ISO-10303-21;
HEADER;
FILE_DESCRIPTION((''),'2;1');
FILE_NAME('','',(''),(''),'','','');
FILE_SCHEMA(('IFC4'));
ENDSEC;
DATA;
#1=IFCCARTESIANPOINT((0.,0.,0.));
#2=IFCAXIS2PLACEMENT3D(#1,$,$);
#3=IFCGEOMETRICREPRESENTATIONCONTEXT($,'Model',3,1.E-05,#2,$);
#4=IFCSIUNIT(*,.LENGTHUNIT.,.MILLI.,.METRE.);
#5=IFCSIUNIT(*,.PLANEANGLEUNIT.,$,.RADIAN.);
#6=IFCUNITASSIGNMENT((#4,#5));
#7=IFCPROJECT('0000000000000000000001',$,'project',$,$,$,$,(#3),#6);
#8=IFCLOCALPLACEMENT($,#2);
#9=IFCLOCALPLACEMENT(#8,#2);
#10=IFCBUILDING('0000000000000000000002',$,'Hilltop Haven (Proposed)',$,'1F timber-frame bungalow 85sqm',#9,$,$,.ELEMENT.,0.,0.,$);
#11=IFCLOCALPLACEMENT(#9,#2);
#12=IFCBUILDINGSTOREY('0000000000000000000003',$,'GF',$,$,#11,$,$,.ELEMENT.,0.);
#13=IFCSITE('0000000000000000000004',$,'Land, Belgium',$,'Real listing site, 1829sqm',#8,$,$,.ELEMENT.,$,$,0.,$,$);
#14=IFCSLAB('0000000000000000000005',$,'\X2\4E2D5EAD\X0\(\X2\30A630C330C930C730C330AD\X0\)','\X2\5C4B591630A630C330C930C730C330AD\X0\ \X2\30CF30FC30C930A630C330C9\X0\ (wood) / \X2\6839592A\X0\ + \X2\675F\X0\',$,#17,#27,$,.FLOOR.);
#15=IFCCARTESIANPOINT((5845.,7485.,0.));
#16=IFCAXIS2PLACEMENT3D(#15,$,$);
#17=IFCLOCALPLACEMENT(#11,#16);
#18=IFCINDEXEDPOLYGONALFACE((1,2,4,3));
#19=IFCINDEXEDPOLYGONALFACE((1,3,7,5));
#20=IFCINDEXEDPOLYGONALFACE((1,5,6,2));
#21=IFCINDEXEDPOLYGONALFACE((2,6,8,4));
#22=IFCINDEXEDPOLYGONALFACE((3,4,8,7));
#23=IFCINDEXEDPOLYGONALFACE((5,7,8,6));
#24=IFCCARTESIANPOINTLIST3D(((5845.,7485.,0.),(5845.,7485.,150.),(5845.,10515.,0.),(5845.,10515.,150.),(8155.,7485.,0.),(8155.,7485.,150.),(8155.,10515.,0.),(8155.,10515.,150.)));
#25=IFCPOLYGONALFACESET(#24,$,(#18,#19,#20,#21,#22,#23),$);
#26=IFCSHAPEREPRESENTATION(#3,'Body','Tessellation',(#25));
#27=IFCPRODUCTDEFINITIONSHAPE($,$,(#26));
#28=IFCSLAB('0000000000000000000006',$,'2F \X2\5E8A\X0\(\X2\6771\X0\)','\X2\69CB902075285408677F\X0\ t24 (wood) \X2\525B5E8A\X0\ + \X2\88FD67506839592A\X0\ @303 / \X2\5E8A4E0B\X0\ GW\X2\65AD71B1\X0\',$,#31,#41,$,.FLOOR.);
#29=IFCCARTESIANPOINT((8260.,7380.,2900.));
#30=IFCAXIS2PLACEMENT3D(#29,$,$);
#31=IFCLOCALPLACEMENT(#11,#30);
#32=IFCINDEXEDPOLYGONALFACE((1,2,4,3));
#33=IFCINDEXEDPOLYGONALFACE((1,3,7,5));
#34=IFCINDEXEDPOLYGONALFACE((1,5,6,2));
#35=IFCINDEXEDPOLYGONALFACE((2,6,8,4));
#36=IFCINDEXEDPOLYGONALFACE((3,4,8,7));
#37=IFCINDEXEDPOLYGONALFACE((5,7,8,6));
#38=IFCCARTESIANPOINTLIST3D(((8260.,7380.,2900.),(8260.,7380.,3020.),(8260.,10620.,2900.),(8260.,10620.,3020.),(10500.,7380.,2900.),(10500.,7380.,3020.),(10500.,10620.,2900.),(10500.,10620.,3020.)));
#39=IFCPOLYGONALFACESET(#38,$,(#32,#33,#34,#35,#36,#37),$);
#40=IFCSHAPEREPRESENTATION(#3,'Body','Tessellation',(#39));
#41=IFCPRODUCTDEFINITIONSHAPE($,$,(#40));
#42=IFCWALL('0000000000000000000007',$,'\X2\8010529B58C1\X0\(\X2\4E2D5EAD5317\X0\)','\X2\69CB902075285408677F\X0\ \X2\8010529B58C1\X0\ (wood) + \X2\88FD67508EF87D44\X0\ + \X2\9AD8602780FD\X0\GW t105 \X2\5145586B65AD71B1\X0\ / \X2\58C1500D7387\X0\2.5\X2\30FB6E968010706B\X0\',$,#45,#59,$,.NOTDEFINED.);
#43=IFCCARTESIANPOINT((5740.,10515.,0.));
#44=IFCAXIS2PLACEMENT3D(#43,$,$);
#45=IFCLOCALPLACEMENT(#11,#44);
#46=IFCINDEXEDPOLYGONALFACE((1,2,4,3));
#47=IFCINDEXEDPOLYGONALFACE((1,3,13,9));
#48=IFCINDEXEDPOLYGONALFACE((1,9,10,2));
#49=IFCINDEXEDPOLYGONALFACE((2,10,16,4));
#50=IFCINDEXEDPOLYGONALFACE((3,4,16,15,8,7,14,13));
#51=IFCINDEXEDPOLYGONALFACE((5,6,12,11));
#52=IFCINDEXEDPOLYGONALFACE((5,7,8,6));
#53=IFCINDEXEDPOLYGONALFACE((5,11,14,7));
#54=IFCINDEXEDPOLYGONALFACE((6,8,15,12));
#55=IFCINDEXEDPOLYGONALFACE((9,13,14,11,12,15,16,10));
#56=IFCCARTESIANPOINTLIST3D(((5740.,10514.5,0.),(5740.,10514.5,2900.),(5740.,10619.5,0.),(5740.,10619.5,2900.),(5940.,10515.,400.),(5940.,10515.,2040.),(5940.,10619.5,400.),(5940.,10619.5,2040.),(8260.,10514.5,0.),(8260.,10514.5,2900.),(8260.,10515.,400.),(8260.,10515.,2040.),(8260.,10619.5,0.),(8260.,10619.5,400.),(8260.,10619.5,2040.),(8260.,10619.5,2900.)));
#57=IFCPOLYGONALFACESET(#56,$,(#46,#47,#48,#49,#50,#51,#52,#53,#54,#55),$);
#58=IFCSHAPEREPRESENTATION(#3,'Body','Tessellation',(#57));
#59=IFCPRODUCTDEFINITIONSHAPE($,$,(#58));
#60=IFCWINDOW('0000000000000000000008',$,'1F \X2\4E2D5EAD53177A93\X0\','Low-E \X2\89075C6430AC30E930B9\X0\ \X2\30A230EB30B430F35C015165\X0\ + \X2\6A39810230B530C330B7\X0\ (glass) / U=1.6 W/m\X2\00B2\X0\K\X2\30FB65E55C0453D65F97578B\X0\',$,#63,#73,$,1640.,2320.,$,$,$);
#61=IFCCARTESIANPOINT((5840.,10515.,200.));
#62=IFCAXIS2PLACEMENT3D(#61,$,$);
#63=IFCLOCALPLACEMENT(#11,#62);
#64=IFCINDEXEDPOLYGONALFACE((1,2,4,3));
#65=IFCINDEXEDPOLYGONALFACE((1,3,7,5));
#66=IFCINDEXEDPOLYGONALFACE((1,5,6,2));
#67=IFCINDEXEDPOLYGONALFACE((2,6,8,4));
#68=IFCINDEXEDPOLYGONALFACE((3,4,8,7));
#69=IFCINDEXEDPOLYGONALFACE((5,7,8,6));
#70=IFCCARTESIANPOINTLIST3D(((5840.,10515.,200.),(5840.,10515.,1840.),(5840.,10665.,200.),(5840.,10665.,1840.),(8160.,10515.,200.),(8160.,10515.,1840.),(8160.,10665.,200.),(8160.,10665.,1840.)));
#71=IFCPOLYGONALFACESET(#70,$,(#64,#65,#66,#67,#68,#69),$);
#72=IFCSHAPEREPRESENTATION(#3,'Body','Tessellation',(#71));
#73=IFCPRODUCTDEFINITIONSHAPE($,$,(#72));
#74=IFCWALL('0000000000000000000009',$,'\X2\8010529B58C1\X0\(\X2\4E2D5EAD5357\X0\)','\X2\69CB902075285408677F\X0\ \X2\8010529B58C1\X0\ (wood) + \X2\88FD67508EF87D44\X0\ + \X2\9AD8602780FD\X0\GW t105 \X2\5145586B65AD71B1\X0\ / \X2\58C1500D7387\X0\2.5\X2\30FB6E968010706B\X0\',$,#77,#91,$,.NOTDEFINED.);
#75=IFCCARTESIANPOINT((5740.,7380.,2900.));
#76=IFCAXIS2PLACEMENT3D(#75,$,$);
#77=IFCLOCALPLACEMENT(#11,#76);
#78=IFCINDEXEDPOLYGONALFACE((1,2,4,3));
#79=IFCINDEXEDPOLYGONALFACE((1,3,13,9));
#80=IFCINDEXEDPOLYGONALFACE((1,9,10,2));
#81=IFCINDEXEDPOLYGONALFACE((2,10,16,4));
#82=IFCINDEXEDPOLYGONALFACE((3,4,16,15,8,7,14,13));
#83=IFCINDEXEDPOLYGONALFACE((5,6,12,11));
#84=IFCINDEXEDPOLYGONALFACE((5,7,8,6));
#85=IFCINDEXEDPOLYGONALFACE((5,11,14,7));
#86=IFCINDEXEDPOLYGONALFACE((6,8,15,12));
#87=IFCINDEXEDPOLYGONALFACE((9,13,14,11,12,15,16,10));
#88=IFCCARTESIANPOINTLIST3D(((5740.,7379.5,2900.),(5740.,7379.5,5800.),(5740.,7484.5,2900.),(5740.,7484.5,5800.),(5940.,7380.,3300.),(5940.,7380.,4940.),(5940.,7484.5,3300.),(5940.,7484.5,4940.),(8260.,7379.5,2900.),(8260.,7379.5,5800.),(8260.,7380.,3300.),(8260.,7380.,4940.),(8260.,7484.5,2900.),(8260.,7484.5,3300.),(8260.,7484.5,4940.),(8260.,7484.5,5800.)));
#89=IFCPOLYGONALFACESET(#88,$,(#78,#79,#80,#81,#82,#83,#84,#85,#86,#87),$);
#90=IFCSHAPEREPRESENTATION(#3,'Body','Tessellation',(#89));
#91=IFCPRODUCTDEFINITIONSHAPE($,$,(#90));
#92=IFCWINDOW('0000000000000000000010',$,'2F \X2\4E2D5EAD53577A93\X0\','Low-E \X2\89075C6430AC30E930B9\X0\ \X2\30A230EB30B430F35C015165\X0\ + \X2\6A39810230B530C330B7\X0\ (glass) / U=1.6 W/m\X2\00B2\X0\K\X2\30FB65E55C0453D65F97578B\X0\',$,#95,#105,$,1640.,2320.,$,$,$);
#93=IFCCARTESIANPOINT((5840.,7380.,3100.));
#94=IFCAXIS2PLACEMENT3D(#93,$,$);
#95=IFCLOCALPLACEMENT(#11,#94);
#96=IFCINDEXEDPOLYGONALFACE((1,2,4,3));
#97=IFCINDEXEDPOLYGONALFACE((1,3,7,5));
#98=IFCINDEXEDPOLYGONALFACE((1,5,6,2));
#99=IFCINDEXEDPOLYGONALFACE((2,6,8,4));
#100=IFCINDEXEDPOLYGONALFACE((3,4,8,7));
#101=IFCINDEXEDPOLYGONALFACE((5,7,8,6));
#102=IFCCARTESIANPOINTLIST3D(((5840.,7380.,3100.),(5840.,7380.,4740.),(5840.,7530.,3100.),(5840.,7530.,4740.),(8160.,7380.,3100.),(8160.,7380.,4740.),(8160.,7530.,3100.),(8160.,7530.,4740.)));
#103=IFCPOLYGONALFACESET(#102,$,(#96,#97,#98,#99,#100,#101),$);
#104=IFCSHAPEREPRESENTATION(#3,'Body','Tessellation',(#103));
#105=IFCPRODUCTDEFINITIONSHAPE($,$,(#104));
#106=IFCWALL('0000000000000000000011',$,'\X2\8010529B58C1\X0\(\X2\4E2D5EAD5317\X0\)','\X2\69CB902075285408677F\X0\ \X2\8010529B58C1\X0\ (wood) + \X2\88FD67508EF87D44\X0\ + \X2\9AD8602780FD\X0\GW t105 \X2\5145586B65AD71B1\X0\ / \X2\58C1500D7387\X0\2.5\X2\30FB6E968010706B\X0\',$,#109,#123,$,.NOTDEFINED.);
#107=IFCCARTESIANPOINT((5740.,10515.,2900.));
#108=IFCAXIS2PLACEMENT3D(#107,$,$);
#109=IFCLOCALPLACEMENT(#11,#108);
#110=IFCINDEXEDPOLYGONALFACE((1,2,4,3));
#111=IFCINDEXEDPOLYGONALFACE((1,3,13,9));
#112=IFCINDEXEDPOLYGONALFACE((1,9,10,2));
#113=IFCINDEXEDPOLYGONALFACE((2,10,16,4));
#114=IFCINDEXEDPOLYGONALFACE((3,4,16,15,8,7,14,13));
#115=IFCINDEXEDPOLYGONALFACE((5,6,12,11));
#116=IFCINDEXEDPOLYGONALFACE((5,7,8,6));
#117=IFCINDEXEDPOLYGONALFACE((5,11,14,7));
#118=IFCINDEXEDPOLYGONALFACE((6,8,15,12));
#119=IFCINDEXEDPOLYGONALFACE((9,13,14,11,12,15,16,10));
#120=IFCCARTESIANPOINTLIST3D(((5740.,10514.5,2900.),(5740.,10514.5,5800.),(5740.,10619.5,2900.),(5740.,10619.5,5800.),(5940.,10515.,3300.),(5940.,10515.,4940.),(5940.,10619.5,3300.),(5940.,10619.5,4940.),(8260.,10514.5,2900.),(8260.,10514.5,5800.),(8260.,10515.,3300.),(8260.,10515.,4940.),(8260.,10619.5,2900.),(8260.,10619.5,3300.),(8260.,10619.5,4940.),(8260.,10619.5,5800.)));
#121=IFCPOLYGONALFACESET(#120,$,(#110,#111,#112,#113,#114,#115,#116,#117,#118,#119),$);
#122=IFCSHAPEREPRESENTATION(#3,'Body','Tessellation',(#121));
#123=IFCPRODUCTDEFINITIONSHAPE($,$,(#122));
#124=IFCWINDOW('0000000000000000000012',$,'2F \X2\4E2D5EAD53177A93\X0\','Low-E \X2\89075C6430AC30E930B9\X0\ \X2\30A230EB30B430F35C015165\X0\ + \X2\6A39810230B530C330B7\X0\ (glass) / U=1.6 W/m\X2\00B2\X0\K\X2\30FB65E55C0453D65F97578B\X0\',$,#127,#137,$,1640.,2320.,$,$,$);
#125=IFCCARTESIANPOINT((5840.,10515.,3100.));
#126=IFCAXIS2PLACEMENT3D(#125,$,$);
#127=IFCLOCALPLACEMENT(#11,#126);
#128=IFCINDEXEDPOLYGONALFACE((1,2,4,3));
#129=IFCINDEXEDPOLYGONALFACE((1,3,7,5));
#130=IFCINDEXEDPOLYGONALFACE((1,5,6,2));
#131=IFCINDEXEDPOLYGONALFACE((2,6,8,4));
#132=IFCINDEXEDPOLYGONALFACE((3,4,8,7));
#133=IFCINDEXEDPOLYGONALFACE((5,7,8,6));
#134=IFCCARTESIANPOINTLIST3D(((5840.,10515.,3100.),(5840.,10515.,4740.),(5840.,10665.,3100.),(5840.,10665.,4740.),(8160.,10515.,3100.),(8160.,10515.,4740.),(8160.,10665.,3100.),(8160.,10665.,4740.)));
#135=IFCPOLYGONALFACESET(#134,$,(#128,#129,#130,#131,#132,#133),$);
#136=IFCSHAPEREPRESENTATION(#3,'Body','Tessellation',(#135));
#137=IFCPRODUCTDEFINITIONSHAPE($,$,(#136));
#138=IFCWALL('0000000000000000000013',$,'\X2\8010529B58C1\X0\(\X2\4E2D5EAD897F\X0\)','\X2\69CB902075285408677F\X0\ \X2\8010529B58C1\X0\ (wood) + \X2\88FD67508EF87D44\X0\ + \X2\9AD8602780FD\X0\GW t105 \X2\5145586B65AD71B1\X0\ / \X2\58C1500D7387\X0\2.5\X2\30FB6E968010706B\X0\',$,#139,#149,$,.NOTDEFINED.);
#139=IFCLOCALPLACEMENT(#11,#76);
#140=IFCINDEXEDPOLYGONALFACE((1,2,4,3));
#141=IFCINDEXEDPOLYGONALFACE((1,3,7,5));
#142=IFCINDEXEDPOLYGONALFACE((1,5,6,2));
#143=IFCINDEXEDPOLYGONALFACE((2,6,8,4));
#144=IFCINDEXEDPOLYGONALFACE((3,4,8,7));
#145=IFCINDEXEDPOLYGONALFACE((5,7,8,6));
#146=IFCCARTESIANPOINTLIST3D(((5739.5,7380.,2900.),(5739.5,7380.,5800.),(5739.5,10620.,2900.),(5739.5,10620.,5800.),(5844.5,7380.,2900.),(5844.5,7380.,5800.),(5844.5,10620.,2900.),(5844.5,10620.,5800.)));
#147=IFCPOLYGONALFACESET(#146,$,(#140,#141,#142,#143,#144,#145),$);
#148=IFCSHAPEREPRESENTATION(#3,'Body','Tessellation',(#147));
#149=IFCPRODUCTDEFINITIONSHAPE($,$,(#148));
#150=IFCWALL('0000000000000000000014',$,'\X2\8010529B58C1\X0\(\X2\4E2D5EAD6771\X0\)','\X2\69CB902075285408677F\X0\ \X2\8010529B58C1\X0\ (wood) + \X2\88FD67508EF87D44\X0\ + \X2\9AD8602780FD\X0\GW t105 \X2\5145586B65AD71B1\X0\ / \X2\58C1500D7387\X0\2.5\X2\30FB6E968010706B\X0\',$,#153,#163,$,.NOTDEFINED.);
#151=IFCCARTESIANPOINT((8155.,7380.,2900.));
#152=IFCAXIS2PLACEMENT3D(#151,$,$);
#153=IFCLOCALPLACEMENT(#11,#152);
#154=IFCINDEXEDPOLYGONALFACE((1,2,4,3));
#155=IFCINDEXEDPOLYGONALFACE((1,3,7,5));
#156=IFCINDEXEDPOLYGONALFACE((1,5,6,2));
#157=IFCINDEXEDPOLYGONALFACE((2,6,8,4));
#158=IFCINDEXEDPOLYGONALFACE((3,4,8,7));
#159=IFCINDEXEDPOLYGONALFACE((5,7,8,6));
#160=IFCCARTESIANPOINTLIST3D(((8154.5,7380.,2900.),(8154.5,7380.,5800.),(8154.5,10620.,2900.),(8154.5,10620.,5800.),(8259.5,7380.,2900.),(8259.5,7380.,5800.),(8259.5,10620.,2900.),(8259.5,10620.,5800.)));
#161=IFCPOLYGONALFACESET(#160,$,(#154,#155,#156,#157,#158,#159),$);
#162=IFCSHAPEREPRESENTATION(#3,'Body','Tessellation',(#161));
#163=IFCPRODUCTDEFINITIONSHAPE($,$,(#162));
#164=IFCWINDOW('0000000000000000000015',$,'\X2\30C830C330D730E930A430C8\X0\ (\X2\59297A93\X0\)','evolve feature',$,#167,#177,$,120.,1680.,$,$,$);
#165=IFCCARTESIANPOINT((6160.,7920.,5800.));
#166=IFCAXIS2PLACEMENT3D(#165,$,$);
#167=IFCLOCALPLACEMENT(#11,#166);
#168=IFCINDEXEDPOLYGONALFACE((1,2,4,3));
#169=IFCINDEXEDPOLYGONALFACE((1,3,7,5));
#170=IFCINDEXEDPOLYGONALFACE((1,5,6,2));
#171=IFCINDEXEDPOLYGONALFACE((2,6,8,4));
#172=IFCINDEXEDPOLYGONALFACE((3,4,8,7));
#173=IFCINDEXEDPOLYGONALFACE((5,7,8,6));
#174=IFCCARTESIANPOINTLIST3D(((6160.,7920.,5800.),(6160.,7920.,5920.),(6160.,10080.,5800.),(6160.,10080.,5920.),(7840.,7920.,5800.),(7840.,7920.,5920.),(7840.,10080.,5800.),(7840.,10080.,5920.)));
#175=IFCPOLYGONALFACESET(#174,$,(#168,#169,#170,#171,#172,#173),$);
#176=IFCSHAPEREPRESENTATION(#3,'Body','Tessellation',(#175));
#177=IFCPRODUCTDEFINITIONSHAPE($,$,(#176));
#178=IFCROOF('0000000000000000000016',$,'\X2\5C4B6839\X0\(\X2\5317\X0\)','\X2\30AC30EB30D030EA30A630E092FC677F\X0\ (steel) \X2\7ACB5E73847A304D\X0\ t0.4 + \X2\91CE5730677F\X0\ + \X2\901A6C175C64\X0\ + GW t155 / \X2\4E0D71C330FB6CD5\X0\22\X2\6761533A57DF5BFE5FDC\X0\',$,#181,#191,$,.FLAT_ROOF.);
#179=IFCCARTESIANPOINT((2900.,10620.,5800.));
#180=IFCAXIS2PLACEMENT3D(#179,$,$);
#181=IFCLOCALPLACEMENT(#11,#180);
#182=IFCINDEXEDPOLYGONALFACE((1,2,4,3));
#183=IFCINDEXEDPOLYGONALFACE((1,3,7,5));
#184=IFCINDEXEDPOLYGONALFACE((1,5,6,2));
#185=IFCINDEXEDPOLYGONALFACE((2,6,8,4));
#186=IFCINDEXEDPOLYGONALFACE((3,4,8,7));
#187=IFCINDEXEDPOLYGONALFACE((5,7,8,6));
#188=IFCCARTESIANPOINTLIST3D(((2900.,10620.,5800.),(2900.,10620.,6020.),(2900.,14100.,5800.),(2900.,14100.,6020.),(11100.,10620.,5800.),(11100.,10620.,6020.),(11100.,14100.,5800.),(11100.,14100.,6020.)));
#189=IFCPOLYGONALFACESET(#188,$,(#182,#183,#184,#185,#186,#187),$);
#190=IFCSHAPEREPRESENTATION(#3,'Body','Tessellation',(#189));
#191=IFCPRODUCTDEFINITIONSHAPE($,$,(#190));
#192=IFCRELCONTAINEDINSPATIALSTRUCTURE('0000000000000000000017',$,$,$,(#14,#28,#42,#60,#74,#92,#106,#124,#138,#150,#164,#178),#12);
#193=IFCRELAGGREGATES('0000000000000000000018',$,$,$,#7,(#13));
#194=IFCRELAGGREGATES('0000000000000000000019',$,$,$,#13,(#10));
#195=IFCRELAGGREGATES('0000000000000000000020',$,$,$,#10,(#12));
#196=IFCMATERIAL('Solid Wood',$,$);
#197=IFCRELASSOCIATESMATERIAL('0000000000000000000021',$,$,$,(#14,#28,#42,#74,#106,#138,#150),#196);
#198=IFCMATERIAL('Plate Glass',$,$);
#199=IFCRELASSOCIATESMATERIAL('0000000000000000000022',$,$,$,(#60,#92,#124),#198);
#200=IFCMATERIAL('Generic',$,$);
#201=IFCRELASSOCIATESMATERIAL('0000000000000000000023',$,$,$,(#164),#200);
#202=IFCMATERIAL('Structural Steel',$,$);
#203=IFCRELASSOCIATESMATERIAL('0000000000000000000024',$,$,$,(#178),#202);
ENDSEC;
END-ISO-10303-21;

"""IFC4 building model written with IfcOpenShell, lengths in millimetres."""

from ifc_helpers import new_model, si_unit, frame, frame_2d, origin, place, context, project, spatial, rectangle, extrude, material, element, fill, save


model = new_model("IFC4")

# Units and contexts
model_context = context("Model", 3, precision=1e-05, world=origin())
ifc_project = project(units=[si_unit("LENGTHUNIT", "METRE", prefix="MILLI"), si_unit("PLANEANGLEUNIT", "RADIAN")], contexts=[model_context])

# Site, building, storey
site_placement = place(None, origin())
site = spatial("IfcSite", under=ifc_project, at=site_placement, Name="Land, Belgium", ObjectType="Real listing site, 1829sqm", CompositionType="ELEMENT", RefElevation=0.0)
building_placement = place(site_placement, origin())
building = spatial("IfcBuilding", under=site, at=building_placement, Name="Hilltop Haven (Proposed)", ObjectType="1F timber-frame bungalow 85sqm", CompositionType="ELEMENT", ElevationOfRefHeight=0.0, ElevationOfTerrain=0.0)
storey_placement = place(building_placement, origin())
storey = spatial("IfcBuildingStorey", under=building, at=storey_placement, Name="GF", CompositionType="ELEMENT", Elevation=0.0)

# Slabs
ifc_material_1 = material(Name="Solid Wood")
slab_1_placement = place(storey_placement, frame((5845.0, 7485.0, 0.0)))
element("IfcSlab", 1, at=slab_1_placement, inside=storey, material=ifc_material_1, Name="中庭(ウッドデッキ)", Description="屋外ウッドデッキ ハードウッド (wood) / 根太 + 束", PredefinedType="FLOOR", context=model_context, shape_type="SweptSolid", body=[
    extrude(rectangle(XDim=2310.0, YDim=3030.0, at=frame_2d((1155.0, 1515.0))), frame((5845.0, 7485.0, 0.0)), (0.0, 0.0, 1.0), 150.0),
])
slab_2_placement = place(storey_placement, frame((8260.0, 7380.0, 2900.0)))
element("IfcSlab", 2, at=slab_2_placement, inside=storey, material=ifc_material_1, Name="2F 床(東)", Description="構造用合板 t24 (wood) 剛床 + 製材根太 @303 / 床下 GW断熱", PredefinedType="FLOOR", context=model_context, shape_type="SweptSolid", body=[
    extrude(rectangle(XDim=2240.0, YDim=3240.0, at=frame_2d((1120.0, 1620.0))), frame((8260.0, 7380.0, 2900.0)), (0.0, 0.0, 1.0), 120.0),
])

# Walls, openings, windows
wall_1_placement = place(storey_placement, frame((5740.0, 10515.0, 0.0)))
wall_1 = element("IfcWall", 3, at=wall_1_placement, inside=storey, material=ifc_material_1, Name="耐力壁(中庭北)", Description="構造用合板 耐力壁 (wood) + 製材軸組 + 高性能GW t105 充填断熱 / 壁倍率2.5・準耐火", PredefinedType="NOTDEFINED", context=model_context, shape_type="SweptSolid", body=[
    extrude(rectangle(XDim=2520.0, YDim=105.0, at=frame_2d((1260.0, 52.0))), frame((5740.0, 10515.0, 0.0)), (0.0, 0.0, 1.0), 2900.0),
])
opening_1_placement = place(storey_placement, frame((5840.0, 10515.0, 200.0)))
opening_1 = element("IfcOpeningElement", 4, at=opening_1_placement, cuts=wall_1, PredefinedType="NOTDEFINED", context=model_context, shape_type="SweptSolid", body=[
    extrude(rectangle(XDim=2320.0, YDim=150.0, at=frame_2d((1160.0, 75.0))), frame((5840.0, 10515.0, 200.0)), (0.0, 0.0, 1.0), 1640.0),
])
ifc_material_2 = material(Name="Plate Glass")
window_1_placement = place(storey_placement, frame((5840.0, 10515.0, 200.0)))
window_1 = element("IfcWindow", 5, at=window_1_placement, inside=storey, material=ifc_material_2, Name="1F 中庭北窓", Description="Low-E 複層ガラス アルゴン封入 + 樹脂サッシ (glass) / U=1.6 W/m²K・日射取得型", OverallHeight=1640.0, OverallWidth=2320.0, context=model_context, shape_type="SweptSolid", body=[
    extrude(rectangle(XDim=2320.0, YDim=150.0, at=frame_2d((1160.0, 75.0))), frame((5840.0, 10515.0, 200.0)), (0.0, 0.0, 1.0), 1640.0),
])
fill(opening_1, window_1)
wall_2_placement = place(storey_placement, frame((5740.0, 7380.0, 2900.0)))
wall_2 = element("IfcWall", 6, at=wall_2_placement, inside=storey, material=ifc_material_1, Name="耐力壁(中庭南)", Description="構造用合板 耐力壁 (wood) + 製材軸組 + 高性能GW t105 充填断熱 / 壁倍率2.5・準耐火", PredefinedType="NOTDEFINED", context=model_context, shape_type="SweptSolid", body=[
    extrude(rectangle(XDim=2520.0, YDim=105.0, at=frame_2d((1260.0, 52.0))), frame((5740.0, 7380.0, 2900.0)), (0.0, 0.0, 1.0), 2900.0),
])
opening_2_placement = place(storey_placement, frame((5840.0, 7380.0, 3100.0)))
opening_2 = element("IfcOpeningElement", 7, at=opening_2_placement, cuts=wall_2, PredefinedType="NOTDEFINED", context=model_context, shape_type="SweptSolid", body=[
    extrude(rectangle(XDim=2320.0, YDim=150.0, at=frame_2d((1160.0, 75.0))), frame((5840.0, 7380.0, 3100.0)), (0.0, 0.0, 1.0), 1640.0),
])
window_2_placement = place(storey_placement, frame((5840.0, 7380.0, 3100.0)))
window_2 = element("IfcWindow", 8, at=window_2_placement, inside=storey, material=ifc_material_2, Name="2F 中庭南窓", Description="Low-E 複層ガラス アルゴン封入 + 樹脂サッシ (glass) / U=1.6 W/m²K・日射取得型", OverallHeight=1640.0, OverallWidth=2320.0, context=model_context, shape_type="SweptSolid", body=[
    extrude(rectangle(XDim=2320.0, YDim=150.0, at=frame_2d((1160.0, 75.0))), frame((5840.0, 7380.0, 3100.0)), (0.0, 0.0, 1.0), 1640.0),
])
fill(opening_2, window_2)
wall_3_placement = place(storey_placement, frame((5740.0, 10515.0, 2900.0)))
wall_3 = element("IfcWall", 9, at=wall_3_placement, inside=storey, material=ifc_material_1, Name="耐力壁(中庭北)", Description="構造用合板 耐力壁 (wood) + 製材軸組 + 高性能GW t105 充填断熱 / 壁倍率2.5・準耐火", PredefinedType="NOTDEFINED", context=model_context, shape_type="SweptSolid", body=[
    extrude(rectangle(XDim=2520.0, YDim=105.0, at=frame_2d((1260.0, 52.0))), frame((5740.0, 10515.0, 2900.0)), (0.0, 0.0, 1.0), 2900.0),
])
opening_3_placement = place(storey_placement, frame((5840.0, 10515.0, 3100.0)))
opening_3 = element("IfcOpeningElement", 10, at=opening_3_placement, cuts=wall_3, PredefinedType="NOTDEFINED", context=model_context, shape_type="SweptSolid", body=[
    extrude(rectangle(XDim=2320.0, YDim=150.0, at=frame_2d((1160.0, 75.0))), frame((5840.0, 10515.0, 3100.0)), (0.0, 0.0, 1.0), 1640.0),
])
window_3_placement = place(storey_placement, frame((5840.0, 10515.0, 3100.0)))
window_3 = element("IfcWindow", 11, at=window_3_placement, inside=storey, material=ifc_material_2, Name="2F 中庭北窓", Description="Low-E 複層ガラス アルゴン封入 + 樹脂サッシ (glass) / U=1.6 W/m²K・日射取得型", OverallHeight=1640.0, OverallWidth=2320.0, context=model_context, shape_type="SweptSolid", body=[
    extrude(rectangle(XDim=2320.0, YDim=150.0, at=frame_2d((1160.0, 75.0))), frame((5840.0, 10515.0, 3100.0)), (0.0, 0.0, 1.0), 1640.0),
])
fill(opening_3, window_3)

# Walls
wall_4_placement = place(storey_placement, frame((5740.0, 7380.0, 2900.0)))
element("IfcWall", 12, at=wall_4_placement, inside=storey, material=ifc_material_1, Name="耐力壁(中庭西)", Description="構造用合板 耐力壁 (wood) + 製材軸組 + 高性能GW t105 充填断熱 / 壁倍率2.5・準耐火", PredefinedType="NOTDEFINED", context=model_context, shape_type="SweptSolid", body=[
    extrude(rectangle(XDim=105.0, YDim=3240.0, at=frame_2d((52.0, 1620.0))), frame((5740.0, 7380.0, 2900.0)), (0.0, 0.0, 1.0), 2900.0),
])
wall_5_placement = place(storey_placement, frame((8155.0, 7380.0, 2900.0)))
element("IfcWall", 13, at=wall_5_placement, inside=storey, material=ifc_material_1, Name="耐力壁(中庭東)", Description="構造用合板 耐力壁 (wood) + 製材軸組 + 高性能GW t105 充填断熱 / 壁倍率2.5・準耐火", PredefinedType="NOTDEFINED", context=model_context, shape_type="SweptSolid", body=[
    extrude(rectangle(XDim=105.0, YDim=3240.0, at=frame_2d((52.0, 1620.0))), frame((8155.0, 7380.0, 2900.0)), (0.0, 0.0, 1.0), 2900.0),
])

# Window
ifc_material_3 = material(Name="Generic")
window_4_placement = place(storey_placement, frame((6160.0, 7920.0, 5800.0)))
element("IfcWindow", 14, at=window_4_placement, inside=storey, material=ifc_material_3, Name="トップライト (天窓)", Description="evolve feature", OverallHeight=120.0, OverallWidth=1680.0, context=model_context, shape_type="SweptSolid", body=[
    extrude(rectangle(XDim=1680.0, YDim=2160.0, at=frame_2d((840.0, 1080.0))), frame((6160.0, 7920.0, 5800.0)), (0.0, 0.0, 1.0), 120.0),
])

# Roof
ifc_material_4 = material(Name="Structural Steel")
roof_1_placement = place(storey_placement, frame((2900.0, 10620.0, 5800.0)))
element("IfcRoof", 15, at=roof_1_placement, inside=storey, material=ifc_material_4, Name="屋根(北)", Description="ガルバリウム鋼板 (steel) 立平葺き t0.4 + 野地板 + 通気層 + GW t155 / 不燃・法22条区域対応", PredefinedType="FLAT_ROOF", context=model_context, shape_type="SweptSolid", body=[
    extrude(rectangle(XDim=8200.0, YDim=3480.0, at=frame_2d((4100.0, 1740.0))), frame((2900.0, 10620.0, 5800.0)), (0.0, 0.0, 1.0), 220.0),
])

save(model, "model.ifc")
